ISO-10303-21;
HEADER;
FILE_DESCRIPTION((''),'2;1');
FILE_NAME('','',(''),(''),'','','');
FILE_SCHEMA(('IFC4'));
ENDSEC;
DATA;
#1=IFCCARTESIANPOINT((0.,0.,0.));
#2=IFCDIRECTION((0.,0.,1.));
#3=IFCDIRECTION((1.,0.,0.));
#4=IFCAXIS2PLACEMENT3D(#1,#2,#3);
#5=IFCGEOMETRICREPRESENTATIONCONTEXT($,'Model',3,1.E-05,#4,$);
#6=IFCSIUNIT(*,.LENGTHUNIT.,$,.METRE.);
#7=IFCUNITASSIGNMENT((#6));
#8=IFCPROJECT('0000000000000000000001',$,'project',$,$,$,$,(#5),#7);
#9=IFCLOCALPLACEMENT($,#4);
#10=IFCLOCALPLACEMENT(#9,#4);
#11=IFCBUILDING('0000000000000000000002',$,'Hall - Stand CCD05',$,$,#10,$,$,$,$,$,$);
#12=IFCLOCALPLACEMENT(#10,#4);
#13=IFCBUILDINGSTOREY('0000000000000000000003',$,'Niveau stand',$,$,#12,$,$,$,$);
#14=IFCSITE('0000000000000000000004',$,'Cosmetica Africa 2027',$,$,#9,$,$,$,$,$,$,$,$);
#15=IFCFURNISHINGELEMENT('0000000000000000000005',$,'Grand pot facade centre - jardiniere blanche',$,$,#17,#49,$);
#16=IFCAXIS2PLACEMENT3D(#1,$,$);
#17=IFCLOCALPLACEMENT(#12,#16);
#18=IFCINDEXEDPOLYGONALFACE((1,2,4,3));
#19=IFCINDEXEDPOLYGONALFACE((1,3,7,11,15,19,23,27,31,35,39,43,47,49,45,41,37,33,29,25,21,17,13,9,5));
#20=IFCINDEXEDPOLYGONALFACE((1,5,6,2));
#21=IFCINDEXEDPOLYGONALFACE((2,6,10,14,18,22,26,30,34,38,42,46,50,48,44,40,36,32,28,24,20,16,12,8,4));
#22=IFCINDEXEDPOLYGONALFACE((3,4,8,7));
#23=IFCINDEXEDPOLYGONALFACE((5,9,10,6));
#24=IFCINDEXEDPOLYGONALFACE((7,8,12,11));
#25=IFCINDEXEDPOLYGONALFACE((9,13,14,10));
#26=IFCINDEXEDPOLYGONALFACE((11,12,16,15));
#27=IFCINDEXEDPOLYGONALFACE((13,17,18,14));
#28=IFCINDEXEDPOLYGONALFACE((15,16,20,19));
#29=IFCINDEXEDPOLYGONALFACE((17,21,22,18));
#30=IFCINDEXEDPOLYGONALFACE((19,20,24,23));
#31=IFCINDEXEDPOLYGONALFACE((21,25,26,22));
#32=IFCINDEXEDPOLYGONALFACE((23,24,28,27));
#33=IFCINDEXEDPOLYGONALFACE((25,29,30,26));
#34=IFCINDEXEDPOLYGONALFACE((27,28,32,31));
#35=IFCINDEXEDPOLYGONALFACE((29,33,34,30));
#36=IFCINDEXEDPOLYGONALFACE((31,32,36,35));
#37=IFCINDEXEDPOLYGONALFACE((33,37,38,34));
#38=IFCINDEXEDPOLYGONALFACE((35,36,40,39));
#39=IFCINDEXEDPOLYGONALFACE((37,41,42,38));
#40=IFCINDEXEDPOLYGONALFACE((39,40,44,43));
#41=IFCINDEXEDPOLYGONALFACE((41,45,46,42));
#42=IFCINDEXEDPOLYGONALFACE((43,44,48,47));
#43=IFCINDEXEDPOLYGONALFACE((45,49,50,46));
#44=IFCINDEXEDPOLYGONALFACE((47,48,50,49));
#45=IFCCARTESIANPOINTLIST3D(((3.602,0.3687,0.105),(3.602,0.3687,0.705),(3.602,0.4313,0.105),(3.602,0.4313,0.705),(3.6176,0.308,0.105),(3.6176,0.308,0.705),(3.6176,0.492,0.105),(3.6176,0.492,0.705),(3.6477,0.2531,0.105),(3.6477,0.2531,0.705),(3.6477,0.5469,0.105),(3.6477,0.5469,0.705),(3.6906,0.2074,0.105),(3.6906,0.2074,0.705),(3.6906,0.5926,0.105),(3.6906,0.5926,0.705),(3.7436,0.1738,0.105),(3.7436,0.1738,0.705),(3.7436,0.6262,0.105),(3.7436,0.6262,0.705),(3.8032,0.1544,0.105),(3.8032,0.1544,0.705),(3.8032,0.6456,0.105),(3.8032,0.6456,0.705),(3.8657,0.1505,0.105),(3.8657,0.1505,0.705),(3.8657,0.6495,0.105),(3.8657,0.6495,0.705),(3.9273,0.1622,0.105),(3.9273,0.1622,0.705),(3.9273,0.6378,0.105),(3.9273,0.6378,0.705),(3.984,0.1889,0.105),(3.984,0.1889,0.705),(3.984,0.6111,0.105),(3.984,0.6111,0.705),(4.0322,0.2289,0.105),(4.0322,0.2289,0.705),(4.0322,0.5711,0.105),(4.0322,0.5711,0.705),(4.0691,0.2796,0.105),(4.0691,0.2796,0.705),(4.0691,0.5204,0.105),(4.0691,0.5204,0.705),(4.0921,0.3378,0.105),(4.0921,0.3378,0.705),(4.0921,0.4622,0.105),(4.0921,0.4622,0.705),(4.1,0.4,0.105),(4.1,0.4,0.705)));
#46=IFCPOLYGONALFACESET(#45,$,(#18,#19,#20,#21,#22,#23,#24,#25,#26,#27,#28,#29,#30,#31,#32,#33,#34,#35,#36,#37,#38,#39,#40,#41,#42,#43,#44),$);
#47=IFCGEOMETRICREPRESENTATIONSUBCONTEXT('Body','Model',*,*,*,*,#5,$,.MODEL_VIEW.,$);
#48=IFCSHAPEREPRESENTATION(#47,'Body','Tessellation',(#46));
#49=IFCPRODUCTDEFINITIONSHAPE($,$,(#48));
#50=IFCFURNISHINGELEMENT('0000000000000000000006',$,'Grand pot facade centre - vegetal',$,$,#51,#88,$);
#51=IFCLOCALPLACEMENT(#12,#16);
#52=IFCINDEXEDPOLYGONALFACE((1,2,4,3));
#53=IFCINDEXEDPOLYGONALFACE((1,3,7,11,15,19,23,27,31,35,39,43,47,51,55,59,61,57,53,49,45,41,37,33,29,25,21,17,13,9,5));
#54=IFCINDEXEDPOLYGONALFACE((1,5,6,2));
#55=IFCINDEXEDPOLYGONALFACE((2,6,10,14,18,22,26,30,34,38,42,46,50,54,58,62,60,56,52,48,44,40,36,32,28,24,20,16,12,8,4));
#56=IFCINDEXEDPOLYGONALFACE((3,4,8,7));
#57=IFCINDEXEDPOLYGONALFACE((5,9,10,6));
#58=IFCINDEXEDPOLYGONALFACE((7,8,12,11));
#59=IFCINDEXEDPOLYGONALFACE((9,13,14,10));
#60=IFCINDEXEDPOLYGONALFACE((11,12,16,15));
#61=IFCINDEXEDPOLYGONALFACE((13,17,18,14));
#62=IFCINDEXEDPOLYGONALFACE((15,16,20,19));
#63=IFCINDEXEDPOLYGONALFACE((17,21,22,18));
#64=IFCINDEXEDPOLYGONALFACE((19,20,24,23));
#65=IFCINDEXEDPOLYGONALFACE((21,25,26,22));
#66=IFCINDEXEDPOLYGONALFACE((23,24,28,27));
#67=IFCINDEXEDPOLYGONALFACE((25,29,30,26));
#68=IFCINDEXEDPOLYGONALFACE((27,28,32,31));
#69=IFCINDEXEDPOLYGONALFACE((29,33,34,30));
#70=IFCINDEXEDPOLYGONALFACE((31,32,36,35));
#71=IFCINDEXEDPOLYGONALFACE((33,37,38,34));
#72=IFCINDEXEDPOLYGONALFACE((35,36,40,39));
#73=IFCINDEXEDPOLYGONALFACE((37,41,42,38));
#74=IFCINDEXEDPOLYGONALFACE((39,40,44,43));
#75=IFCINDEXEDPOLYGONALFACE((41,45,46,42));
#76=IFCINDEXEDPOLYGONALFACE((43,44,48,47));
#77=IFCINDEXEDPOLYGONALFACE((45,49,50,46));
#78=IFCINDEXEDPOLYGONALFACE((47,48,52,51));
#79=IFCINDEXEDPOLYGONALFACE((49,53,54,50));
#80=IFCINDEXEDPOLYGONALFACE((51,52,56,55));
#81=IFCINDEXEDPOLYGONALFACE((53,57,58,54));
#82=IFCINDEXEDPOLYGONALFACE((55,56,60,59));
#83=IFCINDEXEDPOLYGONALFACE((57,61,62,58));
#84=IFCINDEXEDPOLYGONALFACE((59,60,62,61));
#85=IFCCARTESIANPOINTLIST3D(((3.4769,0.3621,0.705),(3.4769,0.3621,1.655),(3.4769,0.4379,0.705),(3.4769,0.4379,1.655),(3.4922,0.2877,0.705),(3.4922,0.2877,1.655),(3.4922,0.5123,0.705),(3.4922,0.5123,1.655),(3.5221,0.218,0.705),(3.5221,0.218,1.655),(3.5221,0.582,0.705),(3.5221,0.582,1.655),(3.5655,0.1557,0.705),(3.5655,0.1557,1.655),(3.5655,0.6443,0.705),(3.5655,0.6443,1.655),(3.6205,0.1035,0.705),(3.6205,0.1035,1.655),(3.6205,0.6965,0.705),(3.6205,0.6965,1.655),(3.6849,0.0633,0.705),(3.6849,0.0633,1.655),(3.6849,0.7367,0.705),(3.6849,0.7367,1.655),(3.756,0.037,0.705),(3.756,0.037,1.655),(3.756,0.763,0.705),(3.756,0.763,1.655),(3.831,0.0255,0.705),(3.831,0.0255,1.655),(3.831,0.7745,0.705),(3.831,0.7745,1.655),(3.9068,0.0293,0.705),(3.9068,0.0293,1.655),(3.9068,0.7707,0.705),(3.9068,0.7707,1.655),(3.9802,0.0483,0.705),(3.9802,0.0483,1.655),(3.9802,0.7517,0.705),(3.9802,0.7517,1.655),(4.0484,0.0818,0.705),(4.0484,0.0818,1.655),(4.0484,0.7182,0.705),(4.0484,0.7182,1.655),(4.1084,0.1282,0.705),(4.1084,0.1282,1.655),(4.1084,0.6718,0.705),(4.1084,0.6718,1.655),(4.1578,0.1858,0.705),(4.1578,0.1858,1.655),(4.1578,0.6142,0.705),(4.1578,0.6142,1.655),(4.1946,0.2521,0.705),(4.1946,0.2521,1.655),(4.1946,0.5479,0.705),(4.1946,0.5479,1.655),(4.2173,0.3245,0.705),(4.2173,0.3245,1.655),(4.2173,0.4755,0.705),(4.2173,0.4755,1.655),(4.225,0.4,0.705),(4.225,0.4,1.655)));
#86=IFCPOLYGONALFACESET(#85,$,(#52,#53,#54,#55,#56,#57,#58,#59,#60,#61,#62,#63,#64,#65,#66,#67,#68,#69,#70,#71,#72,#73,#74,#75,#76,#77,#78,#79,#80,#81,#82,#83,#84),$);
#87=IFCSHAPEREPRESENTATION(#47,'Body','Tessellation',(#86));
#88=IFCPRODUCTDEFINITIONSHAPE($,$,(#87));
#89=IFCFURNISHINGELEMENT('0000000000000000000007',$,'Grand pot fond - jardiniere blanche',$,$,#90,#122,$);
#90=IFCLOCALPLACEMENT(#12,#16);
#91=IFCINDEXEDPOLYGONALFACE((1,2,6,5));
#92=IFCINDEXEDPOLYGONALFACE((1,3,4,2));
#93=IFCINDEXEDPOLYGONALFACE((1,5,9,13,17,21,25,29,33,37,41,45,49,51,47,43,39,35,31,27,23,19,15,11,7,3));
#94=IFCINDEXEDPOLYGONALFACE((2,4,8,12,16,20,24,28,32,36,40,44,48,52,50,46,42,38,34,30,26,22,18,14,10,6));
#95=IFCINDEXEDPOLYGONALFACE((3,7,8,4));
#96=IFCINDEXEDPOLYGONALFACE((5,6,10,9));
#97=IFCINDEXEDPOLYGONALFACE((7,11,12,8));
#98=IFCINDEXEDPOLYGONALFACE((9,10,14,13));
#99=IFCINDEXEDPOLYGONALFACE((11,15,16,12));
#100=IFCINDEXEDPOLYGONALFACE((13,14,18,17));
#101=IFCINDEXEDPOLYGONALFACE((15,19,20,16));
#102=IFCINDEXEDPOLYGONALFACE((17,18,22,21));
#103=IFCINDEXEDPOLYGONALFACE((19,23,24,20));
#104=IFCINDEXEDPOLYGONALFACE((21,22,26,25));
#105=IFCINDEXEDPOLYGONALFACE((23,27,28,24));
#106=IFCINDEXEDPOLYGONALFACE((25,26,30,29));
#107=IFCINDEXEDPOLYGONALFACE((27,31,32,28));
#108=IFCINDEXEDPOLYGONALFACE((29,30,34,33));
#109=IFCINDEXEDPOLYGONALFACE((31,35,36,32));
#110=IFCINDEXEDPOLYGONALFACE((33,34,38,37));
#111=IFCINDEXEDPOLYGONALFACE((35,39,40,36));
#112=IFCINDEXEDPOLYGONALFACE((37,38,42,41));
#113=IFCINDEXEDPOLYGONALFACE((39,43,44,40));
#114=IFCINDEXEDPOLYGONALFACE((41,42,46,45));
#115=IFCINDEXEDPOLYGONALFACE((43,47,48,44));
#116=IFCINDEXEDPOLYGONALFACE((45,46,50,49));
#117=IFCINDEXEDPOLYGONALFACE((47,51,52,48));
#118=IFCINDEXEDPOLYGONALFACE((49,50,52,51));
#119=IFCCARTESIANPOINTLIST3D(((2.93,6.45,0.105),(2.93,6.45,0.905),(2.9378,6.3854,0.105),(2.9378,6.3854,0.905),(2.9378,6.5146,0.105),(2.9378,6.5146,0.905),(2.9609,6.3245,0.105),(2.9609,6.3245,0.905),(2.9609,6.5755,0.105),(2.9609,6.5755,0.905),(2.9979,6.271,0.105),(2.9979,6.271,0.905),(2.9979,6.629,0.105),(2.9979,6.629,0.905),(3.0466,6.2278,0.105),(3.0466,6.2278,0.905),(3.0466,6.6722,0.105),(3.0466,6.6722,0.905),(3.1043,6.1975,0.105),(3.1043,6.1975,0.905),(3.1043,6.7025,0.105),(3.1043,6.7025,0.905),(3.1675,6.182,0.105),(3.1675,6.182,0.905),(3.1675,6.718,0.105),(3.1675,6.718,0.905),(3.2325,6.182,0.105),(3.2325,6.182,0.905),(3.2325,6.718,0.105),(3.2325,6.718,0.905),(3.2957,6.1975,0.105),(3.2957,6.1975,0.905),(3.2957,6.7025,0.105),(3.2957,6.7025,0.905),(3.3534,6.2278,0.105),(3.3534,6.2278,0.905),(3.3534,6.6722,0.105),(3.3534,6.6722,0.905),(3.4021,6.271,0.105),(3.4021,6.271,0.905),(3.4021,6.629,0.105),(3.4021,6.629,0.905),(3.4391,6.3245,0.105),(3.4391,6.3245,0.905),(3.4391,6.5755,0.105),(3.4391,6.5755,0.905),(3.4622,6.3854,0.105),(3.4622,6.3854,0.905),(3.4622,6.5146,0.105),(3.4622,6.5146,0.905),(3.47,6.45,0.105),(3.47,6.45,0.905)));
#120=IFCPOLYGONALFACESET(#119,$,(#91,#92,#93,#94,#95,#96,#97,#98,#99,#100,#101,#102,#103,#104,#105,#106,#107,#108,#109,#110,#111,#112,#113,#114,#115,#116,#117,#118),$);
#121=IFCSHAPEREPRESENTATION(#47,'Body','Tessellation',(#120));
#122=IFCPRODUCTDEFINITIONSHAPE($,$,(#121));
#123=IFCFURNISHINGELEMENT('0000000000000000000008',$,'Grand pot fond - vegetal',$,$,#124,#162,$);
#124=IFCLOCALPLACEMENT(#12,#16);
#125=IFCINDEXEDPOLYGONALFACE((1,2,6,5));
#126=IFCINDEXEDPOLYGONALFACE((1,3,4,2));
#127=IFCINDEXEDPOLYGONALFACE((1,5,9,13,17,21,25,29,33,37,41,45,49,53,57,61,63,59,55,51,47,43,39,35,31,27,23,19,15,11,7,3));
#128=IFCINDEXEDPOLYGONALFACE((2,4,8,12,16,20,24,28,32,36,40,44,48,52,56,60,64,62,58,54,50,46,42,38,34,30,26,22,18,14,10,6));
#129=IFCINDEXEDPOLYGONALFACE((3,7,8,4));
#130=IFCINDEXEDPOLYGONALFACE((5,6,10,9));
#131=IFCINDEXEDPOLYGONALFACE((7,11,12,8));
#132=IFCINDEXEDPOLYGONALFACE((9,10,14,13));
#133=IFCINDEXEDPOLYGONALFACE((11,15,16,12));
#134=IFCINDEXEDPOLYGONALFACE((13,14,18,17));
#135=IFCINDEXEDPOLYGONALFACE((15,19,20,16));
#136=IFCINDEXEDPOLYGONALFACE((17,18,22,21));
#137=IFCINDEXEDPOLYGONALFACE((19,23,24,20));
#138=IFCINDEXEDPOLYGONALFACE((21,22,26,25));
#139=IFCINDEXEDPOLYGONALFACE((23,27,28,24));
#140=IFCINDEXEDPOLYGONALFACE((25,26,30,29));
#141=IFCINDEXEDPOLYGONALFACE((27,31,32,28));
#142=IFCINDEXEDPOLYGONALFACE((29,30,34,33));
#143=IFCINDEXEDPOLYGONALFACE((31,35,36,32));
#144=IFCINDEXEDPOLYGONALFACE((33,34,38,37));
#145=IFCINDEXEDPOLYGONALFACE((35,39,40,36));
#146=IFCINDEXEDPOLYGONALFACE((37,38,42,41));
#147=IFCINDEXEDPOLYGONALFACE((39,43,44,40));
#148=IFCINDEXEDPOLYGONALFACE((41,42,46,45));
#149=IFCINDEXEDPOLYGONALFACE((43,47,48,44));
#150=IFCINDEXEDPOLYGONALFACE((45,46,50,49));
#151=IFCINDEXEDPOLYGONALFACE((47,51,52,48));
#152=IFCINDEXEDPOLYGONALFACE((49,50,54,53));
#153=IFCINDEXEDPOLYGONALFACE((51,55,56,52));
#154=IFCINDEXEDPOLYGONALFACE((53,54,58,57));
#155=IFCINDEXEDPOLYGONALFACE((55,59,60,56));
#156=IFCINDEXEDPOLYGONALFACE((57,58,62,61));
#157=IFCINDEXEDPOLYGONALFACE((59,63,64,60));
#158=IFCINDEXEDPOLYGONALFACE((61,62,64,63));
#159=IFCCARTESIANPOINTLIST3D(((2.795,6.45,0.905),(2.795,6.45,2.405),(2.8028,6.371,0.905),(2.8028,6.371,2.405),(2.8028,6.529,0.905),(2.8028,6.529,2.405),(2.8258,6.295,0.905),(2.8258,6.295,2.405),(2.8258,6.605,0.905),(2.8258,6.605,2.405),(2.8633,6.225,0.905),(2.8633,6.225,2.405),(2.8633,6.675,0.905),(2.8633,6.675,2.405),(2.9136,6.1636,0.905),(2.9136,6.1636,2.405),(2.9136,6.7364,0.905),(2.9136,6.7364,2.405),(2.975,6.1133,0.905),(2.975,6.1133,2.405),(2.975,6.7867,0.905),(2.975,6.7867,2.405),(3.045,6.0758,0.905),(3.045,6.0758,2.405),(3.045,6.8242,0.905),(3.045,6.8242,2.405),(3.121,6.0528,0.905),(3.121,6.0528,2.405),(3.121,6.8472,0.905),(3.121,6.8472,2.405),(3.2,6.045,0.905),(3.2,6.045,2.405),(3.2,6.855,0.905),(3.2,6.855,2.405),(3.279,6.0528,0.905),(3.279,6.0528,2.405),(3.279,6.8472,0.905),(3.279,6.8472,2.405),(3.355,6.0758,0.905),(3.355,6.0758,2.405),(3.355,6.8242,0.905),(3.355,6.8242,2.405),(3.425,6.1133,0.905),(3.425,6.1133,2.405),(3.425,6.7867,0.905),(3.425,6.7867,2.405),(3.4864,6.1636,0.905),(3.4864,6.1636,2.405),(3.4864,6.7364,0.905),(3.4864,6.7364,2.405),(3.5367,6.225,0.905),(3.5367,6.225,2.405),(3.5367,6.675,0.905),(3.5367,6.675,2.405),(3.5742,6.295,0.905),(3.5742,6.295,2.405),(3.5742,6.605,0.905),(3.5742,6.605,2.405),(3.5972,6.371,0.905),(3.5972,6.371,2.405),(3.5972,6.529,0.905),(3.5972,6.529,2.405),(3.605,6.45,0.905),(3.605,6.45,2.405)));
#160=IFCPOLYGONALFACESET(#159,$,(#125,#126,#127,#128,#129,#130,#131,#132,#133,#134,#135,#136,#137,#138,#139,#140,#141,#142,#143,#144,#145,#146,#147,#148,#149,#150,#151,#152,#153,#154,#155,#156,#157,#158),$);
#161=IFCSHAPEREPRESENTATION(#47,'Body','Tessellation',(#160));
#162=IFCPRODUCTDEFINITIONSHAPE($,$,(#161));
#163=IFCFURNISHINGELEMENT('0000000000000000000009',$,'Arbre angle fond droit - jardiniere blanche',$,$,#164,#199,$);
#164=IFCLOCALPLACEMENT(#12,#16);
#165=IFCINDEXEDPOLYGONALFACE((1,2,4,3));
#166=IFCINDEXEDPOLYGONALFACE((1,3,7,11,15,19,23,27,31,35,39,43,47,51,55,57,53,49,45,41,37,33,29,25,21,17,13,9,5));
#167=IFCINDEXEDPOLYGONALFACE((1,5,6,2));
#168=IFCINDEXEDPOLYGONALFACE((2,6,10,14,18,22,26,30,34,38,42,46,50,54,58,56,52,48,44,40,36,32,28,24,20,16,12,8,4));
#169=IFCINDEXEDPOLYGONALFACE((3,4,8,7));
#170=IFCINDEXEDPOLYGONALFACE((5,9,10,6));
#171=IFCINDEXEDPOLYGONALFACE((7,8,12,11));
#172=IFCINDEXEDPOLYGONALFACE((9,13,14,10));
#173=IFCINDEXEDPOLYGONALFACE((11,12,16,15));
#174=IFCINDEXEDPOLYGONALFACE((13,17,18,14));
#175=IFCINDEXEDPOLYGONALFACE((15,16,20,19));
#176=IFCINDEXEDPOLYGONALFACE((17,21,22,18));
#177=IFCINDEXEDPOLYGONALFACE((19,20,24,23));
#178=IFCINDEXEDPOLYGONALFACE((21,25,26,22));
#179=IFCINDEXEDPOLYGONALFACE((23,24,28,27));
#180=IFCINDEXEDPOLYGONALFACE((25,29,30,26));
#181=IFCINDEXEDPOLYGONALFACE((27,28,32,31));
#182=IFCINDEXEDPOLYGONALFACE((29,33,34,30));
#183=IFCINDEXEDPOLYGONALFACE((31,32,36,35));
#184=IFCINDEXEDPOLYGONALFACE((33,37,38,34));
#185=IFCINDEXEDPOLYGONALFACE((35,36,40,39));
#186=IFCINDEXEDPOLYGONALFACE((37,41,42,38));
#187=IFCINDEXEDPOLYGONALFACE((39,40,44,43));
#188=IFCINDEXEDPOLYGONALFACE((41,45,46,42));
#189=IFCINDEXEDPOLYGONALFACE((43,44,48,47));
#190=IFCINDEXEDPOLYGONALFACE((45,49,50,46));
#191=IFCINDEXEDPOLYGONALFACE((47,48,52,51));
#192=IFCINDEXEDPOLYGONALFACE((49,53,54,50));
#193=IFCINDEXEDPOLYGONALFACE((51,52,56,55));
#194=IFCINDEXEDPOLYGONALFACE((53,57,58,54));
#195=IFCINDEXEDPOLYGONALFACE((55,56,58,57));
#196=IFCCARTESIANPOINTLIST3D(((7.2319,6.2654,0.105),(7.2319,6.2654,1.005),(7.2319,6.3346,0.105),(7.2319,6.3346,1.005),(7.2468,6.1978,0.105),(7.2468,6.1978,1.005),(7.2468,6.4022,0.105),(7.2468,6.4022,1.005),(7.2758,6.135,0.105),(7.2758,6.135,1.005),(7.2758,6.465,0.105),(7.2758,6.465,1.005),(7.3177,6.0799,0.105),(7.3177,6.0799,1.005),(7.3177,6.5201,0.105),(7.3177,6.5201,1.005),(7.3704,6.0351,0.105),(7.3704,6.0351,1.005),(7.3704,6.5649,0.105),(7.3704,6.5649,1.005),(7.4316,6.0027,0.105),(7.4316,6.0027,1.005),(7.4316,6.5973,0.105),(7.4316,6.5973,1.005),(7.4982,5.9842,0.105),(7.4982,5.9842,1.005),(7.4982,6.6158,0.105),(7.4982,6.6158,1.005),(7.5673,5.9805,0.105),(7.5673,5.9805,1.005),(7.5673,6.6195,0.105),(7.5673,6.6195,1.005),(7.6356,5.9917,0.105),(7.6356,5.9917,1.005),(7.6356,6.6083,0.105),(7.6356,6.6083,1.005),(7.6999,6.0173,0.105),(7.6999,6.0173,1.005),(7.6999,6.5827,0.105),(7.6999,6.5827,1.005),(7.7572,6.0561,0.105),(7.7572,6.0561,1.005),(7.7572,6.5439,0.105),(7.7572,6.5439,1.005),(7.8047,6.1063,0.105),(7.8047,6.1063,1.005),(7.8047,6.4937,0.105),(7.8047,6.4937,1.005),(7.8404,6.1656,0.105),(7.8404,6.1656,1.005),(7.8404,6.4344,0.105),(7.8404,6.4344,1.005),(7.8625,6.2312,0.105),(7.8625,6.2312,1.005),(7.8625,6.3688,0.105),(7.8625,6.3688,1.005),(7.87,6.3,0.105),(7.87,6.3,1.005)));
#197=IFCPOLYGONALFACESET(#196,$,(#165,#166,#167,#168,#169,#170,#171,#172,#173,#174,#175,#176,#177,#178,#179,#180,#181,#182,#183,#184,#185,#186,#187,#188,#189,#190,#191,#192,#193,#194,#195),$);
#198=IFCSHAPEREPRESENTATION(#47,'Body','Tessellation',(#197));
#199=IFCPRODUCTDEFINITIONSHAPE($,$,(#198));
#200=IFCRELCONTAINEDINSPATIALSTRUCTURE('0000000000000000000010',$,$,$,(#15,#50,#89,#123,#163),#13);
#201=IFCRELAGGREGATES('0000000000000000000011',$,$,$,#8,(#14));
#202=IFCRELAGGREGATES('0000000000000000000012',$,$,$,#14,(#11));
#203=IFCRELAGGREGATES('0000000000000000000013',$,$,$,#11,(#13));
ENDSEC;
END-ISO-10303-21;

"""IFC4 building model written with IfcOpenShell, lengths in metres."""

from ifc_helpers import new_model, si_unit, frame, frame_2d, origin_with_axes, place, context, subcontext, project, spatial, circle, extrude, element, save


model = new_model("IFC4")

# Units and contexts
model_context = context("Model", 3, precision=1e-05, world=origin_with_axes())
body_context = subcontext(model_context, "Body", "Model", "MODEL_VIEW")
ifc_project = project(units=[si_unit("LENGTHUNIT", "METRE")], contexts=[model_context])

# Site, building, storey
site_placement = place(None, origin_with_axes())
site = spatial("IfcSite", under=ifc_project, at=site_placement, Name="Cosmetica Africa 2027")
building_placement = place(site_placement, origin_with_axes())
building = spatial("IfcBuilding", under=site, at=building_placement, Name="Hall - Stand CCD05")
storey_placement = place(building_placement, origin_with_axes())
storey = spatial("IfcBuildingStorey", under=building, at=storey_placement, Name="Niveau stand")

# Furnishing elements
furnishing_1_placement = place(storey_placement, origin_with_axes())
element("IfcFurnishingElement", 1, at=furnishing_1_placement, inside=storey, Name="Grand pot facade centre - jardiniere blanche", context=body_context, shape_type="SweptSolid", body=[
    extrude(circle(Radius=0.25, at=frame_2d((3.85, 0.4))), frame((0.0, 0.0, 0.105)), (0.0, 0.0, 1.0), 0.6),
])
furnishing_2_placement = place(storey_placement, origin_with_axes())
element("IfcFurnishingElement", 2, at=furnishing_2_placement, inside=storey, Name="Grand pot facade centre - vegetal", context=body_context, shape_type="SweptSolid", body=[
    extrude(circle(Radius=0.375, at=frame_2d((3.85, 0.4))), frame((0.0, 0.0, 0.705)), (0.0, 0.0, 1.0), 0.95),
])
furnishing_3_placement = place(storey_placement, origin_with_axes())
element("IfcFurnishingElement", 3, at=furnishing_3_placement, inside=storey, Name="Grand pot fond - jardiniere blanche", context=body_context, shape_type="SweptSolid", body=[
    extrude(circle(Radius=0.27, at=frame_2d((3.2, 6.45))), frame((0.0, 0.0, 0.105)), (0.0, 0.0, 1.0), 0.8),
])
furnishing_4_placement = place(storey_placement, origin_with_axes())
element("IfcFurnishingElement", 4, at=furnishing_4_placement, inside=storey, Name="Grand pot fond - vegetal", context=body_context, shape_type="SweptSolid", body=[
    extrude(circle(Radius=0.405, at=frame_2d((3.2, 6.45))), frame((0.0, 0.0, 0.905)), (0.0, 0.0, 1.0), 1.5),
])
furnishing_5_placement = place(storey_placement, origin_with_axes())
element("IfcFurnishingElement", 5, at=furnishing_5_placement, inside=storey, Name="Arbre angle fond droit - jardiniere blanche", context=body_context, shape_type="SweptSolid", body=[
    extrude(circle(Radius=0.32, at=frame_2d((7.55, 6.3))), frame((0.0, 0.0, 0.105)), (0.0, 0.0, 1.0), 0.9),
])

save(model, "model.ifc")
